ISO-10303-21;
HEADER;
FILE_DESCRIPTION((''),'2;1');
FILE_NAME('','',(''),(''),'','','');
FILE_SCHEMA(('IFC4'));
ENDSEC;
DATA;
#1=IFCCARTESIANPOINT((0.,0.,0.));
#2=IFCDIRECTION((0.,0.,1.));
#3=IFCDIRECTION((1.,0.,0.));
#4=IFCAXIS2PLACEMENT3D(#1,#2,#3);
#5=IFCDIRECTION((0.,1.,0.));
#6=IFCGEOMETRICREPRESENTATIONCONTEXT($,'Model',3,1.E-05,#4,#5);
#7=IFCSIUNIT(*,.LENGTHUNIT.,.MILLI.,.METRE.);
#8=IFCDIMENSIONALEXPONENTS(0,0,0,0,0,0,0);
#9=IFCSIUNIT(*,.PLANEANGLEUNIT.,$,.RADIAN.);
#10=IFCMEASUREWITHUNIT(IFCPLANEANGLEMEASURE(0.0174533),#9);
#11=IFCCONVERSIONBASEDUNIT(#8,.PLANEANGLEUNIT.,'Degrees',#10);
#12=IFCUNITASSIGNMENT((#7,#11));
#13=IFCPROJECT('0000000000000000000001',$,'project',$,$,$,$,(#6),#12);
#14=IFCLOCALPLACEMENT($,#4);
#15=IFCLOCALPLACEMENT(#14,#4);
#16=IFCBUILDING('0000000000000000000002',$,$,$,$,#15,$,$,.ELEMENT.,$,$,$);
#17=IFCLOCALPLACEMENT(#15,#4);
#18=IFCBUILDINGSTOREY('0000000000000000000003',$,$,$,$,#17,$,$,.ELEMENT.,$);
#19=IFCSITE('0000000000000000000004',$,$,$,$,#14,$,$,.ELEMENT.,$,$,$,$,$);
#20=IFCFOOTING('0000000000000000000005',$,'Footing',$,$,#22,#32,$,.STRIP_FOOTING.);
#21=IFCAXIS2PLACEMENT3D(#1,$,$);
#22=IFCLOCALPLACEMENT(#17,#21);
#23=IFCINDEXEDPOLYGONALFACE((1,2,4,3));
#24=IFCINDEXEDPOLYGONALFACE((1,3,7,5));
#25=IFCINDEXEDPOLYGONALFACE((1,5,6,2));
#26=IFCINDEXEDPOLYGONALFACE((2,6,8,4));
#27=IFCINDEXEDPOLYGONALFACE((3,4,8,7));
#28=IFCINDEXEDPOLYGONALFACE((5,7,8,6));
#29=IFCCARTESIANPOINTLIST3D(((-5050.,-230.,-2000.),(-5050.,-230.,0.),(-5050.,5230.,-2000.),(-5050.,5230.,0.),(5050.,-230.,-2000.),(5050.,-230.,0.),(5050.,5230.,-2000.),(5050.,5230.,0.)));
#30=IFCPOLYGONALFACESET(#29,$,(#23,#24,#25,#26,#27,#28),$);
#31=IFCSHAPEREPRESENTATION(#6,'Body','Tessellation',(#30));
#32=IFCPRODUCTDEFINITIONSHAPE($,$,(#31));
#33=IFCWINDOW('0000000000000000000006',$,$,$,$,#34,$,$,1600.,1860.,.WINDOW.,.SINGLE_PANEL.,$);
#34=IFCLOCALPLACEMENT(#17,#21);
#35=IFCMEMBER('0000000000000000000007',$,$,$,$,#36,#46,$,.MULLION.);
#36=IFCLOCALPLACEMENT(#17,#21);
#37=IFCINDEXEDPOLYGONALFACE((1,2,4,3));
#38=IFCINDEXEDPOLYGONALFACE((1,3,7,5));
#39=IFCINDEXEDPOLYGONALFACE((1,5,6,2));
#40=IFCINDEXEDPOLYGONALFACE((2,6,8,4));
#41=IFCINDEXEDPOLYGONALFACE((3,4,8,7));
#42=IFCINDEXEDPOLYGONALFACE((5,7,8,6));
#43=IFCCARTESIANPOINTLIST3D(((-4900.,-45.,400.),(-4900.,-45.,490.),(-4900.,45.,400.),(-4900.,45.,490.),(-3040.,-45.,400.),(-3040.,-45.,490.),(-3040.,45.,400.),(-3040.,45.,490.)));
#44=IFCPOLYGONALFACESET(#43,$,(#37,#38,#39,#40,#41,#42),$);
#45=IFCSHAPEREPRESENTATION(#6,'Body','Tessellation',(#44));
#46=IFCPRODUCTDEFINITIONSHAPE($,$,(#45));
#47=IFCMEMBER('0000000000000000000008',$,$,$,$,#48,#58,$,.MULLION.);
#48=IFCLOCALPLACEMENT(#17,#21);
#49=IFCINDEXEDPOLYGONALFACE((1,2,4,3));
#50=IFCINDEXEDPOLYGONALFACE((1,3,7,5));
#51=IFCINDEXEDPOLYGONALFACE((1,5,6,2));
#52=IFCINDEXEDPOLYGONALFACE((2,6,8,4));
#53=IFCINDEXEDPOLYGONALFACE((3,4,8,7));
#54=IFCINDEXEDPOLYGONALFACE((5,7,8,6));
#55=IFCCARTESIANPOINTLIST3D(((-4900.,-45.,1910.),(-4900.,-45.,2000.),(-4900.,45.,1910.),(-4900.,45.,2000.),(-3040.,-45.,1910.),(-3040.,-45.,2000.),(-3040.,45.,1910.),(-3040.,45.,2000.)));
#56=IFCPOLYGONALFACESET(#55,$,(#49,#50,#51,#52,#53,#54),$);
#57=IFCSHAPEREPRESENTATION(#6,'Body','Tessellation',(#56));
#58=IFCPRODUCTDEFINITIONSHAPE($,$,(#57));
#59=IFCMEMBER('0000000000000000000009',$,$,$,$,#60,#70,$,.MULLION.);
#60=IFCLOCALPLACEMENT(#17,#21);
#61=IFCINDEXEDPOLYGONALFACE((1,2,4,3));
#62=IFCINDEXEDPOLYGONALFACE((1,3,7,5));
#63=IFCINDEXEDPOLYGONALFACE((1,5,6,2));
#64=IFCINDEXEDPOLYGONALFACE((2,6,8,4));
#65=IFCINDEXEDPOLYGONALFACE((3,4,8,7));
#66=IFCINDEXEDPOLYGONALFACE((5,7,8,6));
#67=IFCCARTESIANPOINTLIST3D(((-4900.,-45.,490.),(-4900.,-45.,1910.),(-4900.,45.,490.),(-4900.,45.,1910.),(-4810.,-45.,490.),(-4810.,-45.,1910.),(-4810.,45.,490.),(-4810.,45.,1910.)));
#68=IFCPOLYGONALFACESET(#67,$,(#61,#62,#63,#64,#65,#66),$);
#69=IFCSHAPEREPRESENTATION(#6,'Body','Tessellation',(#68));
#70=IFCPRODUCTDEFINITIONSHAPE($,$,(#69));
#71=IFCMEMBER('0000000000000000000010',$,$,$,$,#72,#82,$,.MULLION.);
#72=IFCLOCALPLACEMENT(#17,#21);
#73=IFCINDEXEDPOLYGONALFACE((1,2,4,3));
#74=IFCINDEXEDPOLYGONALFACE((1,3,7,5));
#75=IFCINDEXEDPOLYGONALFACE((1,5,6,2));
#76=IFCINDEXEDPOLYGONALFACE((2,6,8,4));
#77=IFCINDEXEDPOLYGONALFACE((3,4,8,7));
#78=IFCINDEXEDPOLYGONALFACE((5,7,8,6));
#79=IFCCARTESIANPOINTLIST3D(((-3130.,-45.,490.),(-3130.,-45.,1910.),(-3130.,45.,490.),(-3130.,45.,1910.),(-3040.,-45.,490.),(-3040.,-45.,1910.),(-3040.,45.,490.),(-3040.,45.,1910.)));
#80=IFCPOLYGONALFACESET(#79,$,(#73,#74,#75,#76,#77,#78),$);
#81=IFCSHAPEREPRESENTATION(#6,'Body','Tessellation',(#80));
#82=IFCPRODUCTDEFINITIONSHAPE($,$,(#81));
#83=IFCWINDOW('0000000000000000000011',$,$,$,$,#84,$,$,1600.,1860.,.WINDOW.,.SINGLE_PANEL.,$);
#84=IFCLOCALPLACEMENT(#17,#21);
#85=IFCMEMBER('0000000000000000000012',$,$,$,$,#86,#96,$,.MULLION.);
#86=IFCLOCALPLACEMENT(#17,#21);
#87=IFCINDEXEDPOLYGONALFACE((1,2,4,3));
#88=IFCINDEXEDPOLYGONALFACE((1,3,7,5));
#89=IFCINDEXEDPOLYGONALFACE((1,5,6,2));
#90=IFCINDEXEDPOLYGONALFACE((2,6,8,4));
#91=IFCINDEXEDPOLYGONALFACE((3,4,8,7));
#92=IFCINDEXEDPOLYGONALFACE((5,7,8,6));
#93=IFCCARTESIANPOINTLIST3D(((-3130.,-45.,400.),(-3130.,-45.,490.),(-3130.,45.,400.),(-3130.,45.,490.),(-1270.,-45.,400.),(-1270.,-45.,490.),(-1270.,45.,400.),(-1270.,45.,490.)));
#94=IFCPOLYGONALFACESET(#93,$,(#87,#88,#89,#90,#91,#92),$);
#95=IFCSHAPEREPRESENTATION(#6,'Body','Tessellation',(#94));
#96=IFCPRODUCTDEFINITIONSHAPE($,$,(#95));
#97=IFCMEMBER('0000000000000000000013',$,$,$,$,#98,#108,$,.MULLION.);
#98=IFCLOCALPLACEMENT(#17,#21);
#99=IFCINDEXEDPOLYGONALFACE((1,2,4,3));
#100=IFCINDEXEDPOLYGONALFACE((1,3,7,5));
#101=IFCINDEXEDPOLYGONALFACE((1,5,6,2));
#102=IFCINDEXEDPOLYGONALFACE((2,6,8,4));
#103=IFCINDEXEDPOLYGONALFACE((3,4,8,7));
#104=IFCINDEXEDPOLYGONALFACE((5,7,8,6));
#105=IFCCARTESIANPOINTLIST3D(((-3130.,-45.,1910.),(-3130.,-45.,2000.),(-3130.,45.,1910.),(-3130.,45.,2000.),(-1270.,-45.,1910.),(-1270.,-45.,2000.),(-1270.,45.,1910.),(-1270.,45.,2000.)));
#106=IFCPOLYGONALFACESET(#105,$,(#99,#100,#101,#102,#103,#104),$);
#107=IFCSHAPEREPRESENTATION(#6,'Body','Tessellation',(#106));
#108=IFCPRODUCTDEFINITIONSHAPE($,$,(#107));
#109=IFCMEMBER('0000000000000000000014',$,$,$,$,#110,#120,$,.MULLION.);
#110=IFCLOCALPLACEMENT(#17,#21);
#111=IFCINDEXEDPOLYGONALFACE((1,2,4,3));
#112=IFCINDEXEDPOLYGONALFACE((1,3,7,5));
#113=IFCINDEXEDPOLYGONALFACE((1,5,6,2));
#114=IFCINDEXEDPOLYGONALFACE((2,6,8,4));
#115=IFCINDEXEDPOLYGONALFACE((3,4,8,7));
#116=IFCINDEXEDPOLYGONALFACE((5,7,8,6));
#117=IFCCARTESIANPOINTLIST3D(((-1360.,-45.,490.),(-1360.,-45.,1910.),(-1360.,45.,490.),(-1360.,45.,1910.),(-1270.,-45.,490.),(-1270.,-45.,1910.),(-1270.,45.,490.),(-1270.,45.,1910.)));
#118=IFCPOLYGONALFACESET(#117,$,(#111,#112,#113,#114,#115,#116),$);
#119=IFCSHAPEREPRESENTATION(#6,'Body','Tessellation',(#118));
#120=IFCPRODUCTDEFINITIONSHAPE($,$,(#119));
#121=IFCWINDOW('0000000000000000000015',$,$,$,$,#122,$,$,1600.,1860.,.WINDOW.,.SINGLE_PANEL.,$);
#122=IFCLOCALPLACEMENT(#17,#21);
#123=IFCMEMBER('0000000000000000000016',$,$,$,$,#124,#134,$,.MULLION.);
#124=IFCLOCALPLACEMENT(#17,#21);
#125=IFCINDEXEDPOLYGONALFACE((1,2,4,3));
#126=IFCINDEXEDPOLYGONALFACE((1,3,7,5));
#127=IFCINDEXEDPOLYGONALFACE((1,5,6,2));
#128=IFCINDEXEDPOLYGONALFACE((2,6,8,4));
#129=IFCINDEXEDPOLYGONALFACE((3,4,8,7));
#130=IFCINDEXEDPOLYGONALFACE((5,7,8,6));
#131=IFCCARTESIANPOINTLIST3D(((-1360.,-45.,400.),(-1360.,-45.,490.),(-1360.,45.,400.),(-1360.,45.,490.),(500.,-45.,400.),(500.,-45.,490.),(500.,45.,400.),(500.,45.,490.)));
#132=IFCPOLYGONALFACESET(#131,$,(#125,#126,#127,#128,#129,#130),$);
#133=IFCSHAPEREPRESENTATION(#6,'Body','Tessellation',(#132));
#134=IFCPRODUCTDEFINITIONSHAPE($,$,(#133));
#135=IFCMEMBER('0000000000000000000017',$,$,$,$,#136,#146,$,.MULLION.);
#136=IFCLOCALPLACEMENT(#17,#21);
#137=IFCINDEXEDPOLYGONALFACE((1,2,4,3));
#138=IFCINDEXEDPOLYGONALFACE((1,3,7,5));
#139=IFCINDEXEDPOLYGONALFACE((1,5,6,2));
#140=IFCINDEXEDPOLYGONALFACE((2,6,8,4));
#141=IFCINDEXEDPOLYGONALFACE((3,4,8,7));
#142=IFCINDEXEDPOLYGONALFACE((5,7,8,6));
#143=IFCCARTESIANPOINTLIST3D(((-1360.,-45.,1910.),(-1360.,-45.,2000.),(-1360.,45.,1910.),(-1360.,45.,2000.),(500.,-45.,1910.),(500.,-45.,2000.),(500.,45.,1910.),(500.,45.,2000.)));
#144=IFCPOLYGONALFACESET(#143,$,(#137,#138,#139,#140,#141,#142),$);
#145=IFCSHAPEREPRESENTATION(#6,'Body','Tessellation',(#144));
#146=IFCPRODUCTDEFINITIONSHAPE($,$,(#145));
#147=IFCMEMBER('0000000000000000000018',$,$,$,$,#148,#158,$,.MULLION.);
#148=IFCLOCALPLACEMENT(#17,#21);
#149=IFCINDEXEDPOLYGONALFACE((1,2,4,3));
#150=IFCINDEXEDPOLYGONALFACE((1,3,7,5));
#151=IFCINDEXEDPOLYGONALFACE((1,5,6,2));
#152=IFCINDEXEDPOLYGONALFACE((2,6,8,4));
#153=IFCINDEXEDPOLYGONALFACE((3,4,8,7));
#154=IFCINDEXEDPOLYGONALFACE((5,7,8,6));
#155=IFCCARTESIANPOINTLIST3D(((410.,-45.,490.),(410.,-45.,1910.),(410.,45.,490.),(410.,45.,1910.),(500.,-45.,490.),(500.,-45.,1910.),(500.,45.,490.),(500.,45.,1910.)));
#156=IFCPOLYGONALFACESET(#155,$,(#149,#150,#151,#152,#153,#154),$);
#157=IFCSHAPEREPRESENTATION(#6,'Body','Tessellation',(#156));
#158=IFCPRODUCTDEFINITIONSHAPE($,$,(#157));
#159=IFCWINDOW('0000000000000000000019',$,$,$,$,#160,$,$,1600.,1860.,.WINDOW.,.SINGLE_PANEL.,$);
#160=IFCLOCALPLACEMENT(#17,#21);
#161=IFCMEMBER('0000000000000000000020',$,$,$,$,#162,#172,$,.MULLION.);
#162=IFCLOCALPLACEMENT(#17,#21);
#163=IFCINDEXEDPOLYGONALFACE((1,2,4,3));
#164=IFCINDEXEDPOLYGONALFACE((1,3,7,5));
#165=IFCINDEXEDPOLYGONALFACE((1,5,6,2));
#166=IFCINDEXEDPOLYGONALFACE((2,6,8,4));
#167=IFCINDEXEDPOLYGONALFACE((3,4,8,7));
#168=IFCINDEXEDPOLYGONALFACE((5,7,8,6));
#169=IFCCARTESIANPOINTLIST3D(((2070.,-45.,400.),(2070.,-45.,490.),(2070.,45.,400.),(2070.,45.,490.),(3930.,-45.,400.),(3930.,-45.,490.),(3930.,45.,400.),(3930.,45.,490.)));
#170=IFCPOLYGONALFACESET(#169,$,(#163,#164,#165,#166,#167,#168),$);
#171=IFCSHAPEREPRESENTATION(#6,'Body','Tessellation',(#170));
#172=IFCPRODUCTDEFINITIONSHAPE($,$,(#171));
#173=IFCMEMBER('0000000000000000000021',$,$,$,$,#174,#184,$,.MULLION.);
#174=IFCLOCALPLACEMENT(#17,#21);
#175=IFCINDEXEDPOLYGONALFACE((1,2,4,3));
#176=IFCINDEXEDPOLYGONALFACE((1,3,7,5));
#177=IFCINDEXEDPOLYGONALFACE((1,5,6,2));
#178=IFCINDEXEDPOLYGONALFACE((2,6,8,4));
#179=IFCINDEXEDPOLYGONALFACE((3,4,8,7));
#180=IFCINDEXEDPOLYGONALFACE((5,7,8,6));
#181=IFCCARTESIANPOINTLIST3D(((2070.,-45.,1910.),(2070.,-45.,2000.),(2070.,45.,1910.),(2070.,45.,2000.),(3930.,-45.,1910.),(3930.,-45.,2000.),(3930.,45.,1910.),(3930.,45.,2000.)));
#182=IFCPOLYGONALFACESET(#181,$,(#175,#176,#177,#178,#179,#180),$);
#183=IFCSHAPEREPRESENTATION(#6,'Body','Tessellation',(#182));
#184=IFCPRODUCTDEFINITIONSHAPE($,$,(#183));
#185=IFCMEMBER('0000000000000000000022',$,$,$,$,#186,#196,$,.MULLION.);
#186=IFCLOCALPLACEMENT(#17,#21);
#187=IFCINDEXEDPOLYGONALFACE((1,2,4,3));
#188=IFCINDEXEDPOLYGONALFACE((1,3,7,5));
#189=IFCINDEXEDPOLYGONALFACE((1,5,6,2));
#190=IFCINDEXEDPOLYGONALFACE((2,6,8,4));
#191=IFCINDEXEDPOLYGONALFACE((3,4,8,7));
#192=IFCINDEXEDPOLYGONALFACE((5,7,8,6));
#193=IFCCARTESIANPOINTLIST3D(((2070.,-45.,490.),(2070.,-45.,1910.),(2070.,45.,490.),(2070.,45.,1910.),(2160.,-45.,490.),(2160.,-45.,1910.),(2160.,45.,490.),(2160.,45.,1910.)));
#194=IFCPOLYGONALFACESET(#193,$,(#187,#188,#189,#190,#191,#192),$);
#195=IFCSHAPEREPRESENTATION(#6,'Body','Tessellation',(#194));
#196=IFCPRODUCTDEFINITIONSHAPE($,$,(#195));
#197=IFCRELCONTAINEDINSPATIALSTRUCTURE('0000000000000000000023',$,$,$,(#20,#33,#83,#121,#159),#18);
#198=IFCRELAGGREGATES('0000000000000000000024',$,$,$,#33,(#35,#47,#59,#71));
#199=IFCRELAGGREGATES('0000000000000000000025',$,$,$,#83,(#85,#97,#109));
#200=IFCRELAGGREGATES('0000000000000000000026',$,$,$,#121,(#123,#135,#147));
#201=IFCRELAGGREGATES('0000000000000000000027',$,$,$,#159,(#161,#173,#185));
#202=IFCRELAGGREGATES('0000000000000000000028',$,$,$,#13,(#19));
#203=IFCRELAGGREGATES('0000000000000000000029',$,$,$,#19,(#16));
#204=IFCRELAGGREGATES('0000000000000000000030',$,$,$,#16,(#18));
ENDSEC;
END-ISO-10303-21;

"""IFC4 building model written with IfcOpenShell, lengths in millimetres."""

from ifc_helpers import new_model, entity, si_unit, converted_unit, direction, frame, origin_with_axes, place, context, project, spatial, polyline, outline, extrude, element, aggregate, save


model = new_model("IFC4")

# Units and contexts
model_context = context("Model", 3, precision=1e-05, world=origin_with_axes(), true_north=direction((0.0, 1.0, 0.0)))
ifc_project = project(units=[si_unit("LENGTHUNIT", "METRE", prefix="MILLI"), converted_unit("PLANEANGLEUNIT", "Degrees", entity("IfcPlaneAngleMeasure", 0.0174533), si_unit("PLANEANGLEUNIT", "RADIAN"), dimensions=[0, 0, 0, 0, 0, 0, 0])], contexts=[model_context])

# Site, building, storey
site_placement = place(None, origin_with_axes())
site = spatial("IfcSite", under=ifc_project, at=site_placement, CompositionType="ELEMENT")
building_placement = place(site_placement, origin_with_axes())
building = spatial("IfcBuilding", under=site, at=building_placement, CompositionType="ELEMENT")
storey_placement = place(building_placement, origin_with_axes())
storey = spatial("IfcBuildingStorey", under=building, at=storey_placement, CompositionType="ELEMENT")

# Footing
footing_placement = place(None, frame((0.0, 2500.0, -2000.0), z_axis=(0.0, 0.0, 1.0), x_axis=(1.0, 0.0, 0.0)))
element("IfcFooting", 1, at=footing_placement, inside=storey, Name="Footing", PredefinedType="STRIP_FOOTING", context=model_context, shape_type="SweptSolid", body=[
    extrude(outline(polyline([(-5050.0, -2730.0), (5050.0, -2730.0), (5050.0, 2730.0), (-5050.0, 2730.0), (-5050.0, -2730.0), (-5050.0, -2730.0)])), origin_with_axes(), (0.0, 0.0, 1.0), 2000.0),
])

# Windows, members
window_1_placement = place(storey_placement, frame((-4900.0, -45.0, 400.0), z_axis=(0.0, 0.0, 1.0), x_axis=(1.0, 0.0, 0.0)))
window_1 = element("IfcWindow", 2, at=window_1_placement, inside=storey, OverallHeight=1600.0, OverallWidth=1860.0, PartitioningType="SINGLE_PANEL", PredefinedType="WINDOW")
member_1_placement = place(window_1_placement, frame((930.0, 45.0, 0.0), z_axis=(0.0, 0.0, 1.0), x_axis=(1.0, 0.0, 0.0)))
member_1 = element("IfcMember", 3, at=member_1_placement, PredefinedType="MULLION", context=model_context, shape_type="SweptSolid", body=[
    extrude(outline(polyline([(-930.0, -45.0), (930.0, -45.0), (930.0, 45.0), (-930.0, 45.0), (-930.0, -45.0), (-930.0, -45.0)])), origin_with_axes(), (0.0, 0.0, 1.0), 90.0),
])
member_2_placement = place(window_1_placement, frame((930.0, 45.0, 1510.0), z_axis=(0.0, 0.0, 1.0), x_axis=(1.0, 0.0, 0.0)))
member_2 = element("IfcMember", 4, at=member_2_placement, PredefinedType="MULLION", context=model_context, shape_type="SweptSolid", body=[
    extrude(outline(polyline([(-930.0, -45.0), (930.0, -45.0), (930.0, 45.0), (-930.0, 45.0), (-930.0, -45.0), (-930.0, -45.0)])), origin_with_axes(), (0.0, 0.0, 1.0), 90.0),
])
member_3_placement = place(window_1_placement, frame((45.0, 45.0, 90.0), z_axis=(0.0, 0.0, 1.0), x_axis=(1.0, 0.0, 0.0)))
member_3 = element("IfcMember", 5, at=member_3_placement, PredefinedType="MULLION", context=model_context, shape_type="SweptSolid", body=[
    extrude(outline(polyline([(-45.0, -45.0), (45.0, -45.0), (45.0, 45.0), (-45.0, 45.0), (-45.0, -45.0), (-45.0, -45.0)])), origin_with_axes(), (0.0, 0.0, 1.0), 1420.0),
])
member_4_placement = place(window_1_placement, frame((1815.0, 45.0, 90.0), z_axis=(0.0, 0.0, 1.0), x_axis=(1.0, 0.0, 0.0)))
member_4 = element("IfcMember", 6, at=member_4_placement, PredefinedType="MULLION", context=model_context, shape_type="SweptSolid", body=[
    extrude(outline(polyline([(-45.0, -45.0), (45.0, -45.0), (45.0, 45.0), (-45.0, 45.0), (-45.0, -45.0), (-45.0, -45.0)])), origin_with_axes(), (0.0, 0.0, 1.0), 1420.0),
])
window_2_placement = place(storey_placement, frame((-3130.0, -45.0, 400.0), z_axis=(0.0, 0.0, 1.0), x_axis=(1.0, 0.0, 0.0)))
window_2 = element("IfcWindow", 7, at=window_2_placement, inside=storey, OverallHeight=1600.0, OverallWidth=1860.0, PartitioningType="SINGLE_PANEL", PredefinedType="WINDOW")
member_5_placement = place(window_2_placement, frame((930.0, 45.0, 0.0), z_axis=(0.0, 0.0, 1.0), x_axis=(1.0, 0.0, 0.0)))
member_5 = element("IfcMember", 8, at=member_5_placement, PredefinedType="MULLION", context=model_context, shape_type="SweptSolid", body=[
    extrude(outline(polyline([(-930.0, -45.0), (930.0, -45.0), (930.0, 45.0), (-930.0, 45.0), (-930.0, -45.0), (-930.0, -45.0)])), origin_with_axes(), (0.0, 0.0, 1.0), 90.0),
])
member_6_placement = place(window_2_placement, frame((930.0, 45.0, 1510.0), z_axis=(0.0, 0.0, 1.0), x_axis=(1.0, 0.0, 0.0)))
member_6 = element("IfcMember", 9, at=member_6_placement, PredefinedType="MULLION", context=model_context, shape_type="SweptSolid", body=[
    extrude(outline(polyline([(-930.0, -45.0), (930.0, -45.0), (930.0, 45.0), (-930.0, 45.0), (-930.0, -45.0), (-930.0, -45.0)])), origin_with_axes(), (0.0, 0.0, 1.0), 90.0),
])
member_7_placement = place(window_2_placement, frame((1815.0, 45.0, 90.0), z_axis=(0.0, 0.0, 1.0), x_axis=(1.0, 0.0, 0.0)))
member_7 = element("IfcMember", 10, at=member_7_placement, PredefinedType="MULLION", context=model_context, shape_type="SweptSolid", body=[
    extrude(outline(polyline([(-45.0, -45.0), (45.0, -45.0), (45.0, 45.0), (-45.0, 45.0), (-45.0, -45.0), (-45.0, -45.0)])), origin_with_axes(), (0.0, 0.0, 1.0), 1420.0),
])
window_3_placement = place(storey_placement, frame((-1360.0, -45.0, 400.0), z_axis=(0.0, 0.0, 1.0), x_axis=(1.0, 0.0, 0.0)))
window_3 = element("IfcWindow", 11, at=window_3_placement, inside=storey, OverallHeight=1600.0, OverallWidth=1860.0, PartitioningType="SINGLE_PANEL", PredefinedType="WINDOW")
member_8_placement = place(window_3_placement, frame((930.0, 45.0, 0.0), z_axis=(0.0, 0.0, 1.0), x_axis=(1.0, 0.0, 0.0)))
member_8 = element("IfcMember", 12, at=member_8_placement, PredefinedType="MULLION", context=model_context, shape_type="SweptSolid", body=[
    extrude(outline(polyline([(-930.0, -45.0), (930.0, -45.0), (930.0, 45.0), (-930.0, 45.0), (-930.0, -45.0), (-930.0, -45.0)])), origin_with_axes(), (0.0, 0.0, 1.0), 90.0),
])
member_9_placement = place(window_3_placement, frame((930.0, 45.0, 1510.0), z_axis=(0.0, 0.0, 1.0), x_axis=(1.0, 0.0, 0.0)))
member_9 = element("IfcMember", 13, at=member_9_placement, PredefinedType="MULLION", context=model_context, shape_type="SweptSolid", body=[
    extrude(outline(polyline([(-930.0, -45.0), (930.0, -45.0), (930.0, 45.0), (-930.0, 45.0), (-930.0, -45.0), (-930.0, -45.0)])), origin_with_axes(), (0.0, 0.0, 1.0), 90.0),
])
member_10_placement = place(window_3_placement, frame((1815.0, 45.0, 90.0), z_axis=(0.0, 0.0, 1.0), x_axis=(1.0, 0.0, 0.0)))
member_10 = element("IfcMember", 14, at=member_10_placement, PredefinedType="MULLION", context=model_context, shape_type="SweptSolid", body=[
    extrude(outline(polyline([(-45.0, -45.0), (45.0, -45.0), (45.0, 45.0), (-45.0, 45.0), (-45.0, -45.0), (-45.0, -45.0)])), origin_with_axes(), (0.0, 0.0, 1.0), 1420.0),
])
window_4_placement = place(storey_placement, frame((2070.0, -45.0, 400.0), z_axis=(0.0, 0.0, 1.0), x_axis=(1.0, 0.0, 0.0)))
window_4 = element("IfcWindow", 15, at=window_4_placement, inside=storey, OverallHeight=1600.0, OverallWidth=1860.0, PartitioningType="SINGLE_PANEL", PredefinedType="WINDOW")
member_11_placement = place(window_4_placement, frame((930.0, 45.0, 0.0), z_axis=(0.0, 0.0, 1.0), x_axis=(1.0, 0.0, 0.0)))
member_11 = element("IfcMember", 16, at=member_11_placement, PredefinedType="MULLION", context=model_context, shape_type="SweptSolid", body=[
    extrude(outline(polyline([(-930.0, -45.0), (930.0, -45.0), (930.0, 45.0), (-930.0, 45.0), (-930.0, -45.0), (-930.0, -45.0)])), origin_with_axes(), (0.0, 0.0, 1.0), 90.0),
])
member_12_placement = place(window_4_placement, frame((930.0, 45.0, 1510.0), z_axis=(0.0, 0.0, 1.0), x_axis=(1.0, 0.0, 0.0)))
member_12 = element("IfcMember", 17, at=member_12_placement, PredefinedType="MULLION", context=model_context, shape_type="SweptSolid", body=[
    extrude(outline(polyline([(-930.0, -45.0), (930.0, -45.0), (930.0, 45.0), (-930.0, 45.0), (-930.0, -45.0), (-930.0, -45.0)])), origin_with_axes(), (0.0, 0.0, 1.0), 90.0),
])
member_13_placement = place(window_4_placement, frame((45.0, 45.0, 90.0), z_axis=(0.0, 0.0, 1.0), x_axis=(1.0, 0.0, 0.0)))
member_13 = element("IfcMember", 18, at=member_13_placement, PredefinedType="MULLION", context=model_context, shape_type="SweptSolid", body=[
    extrude(outline(polyline([(-45.0, -45.0), (45.0, -45.0), (45.0, 45.0), (-45.0, 45.0), (-45.0, -45.0), (-45.0, -45.0)])), origin_with_axes(), (0.0, 0.0, 1.0), 1420.0),
])

aggregate(window_1, [member_1, member_2, member_3, member_4])
aggregate(window_2, [member_5, member_6, member_7])
aggregate(window_3, [member_8, member_9, member_10])
aggregate(window_4, [member_11, member_12, member_13])

save(model, "model.ifc")
